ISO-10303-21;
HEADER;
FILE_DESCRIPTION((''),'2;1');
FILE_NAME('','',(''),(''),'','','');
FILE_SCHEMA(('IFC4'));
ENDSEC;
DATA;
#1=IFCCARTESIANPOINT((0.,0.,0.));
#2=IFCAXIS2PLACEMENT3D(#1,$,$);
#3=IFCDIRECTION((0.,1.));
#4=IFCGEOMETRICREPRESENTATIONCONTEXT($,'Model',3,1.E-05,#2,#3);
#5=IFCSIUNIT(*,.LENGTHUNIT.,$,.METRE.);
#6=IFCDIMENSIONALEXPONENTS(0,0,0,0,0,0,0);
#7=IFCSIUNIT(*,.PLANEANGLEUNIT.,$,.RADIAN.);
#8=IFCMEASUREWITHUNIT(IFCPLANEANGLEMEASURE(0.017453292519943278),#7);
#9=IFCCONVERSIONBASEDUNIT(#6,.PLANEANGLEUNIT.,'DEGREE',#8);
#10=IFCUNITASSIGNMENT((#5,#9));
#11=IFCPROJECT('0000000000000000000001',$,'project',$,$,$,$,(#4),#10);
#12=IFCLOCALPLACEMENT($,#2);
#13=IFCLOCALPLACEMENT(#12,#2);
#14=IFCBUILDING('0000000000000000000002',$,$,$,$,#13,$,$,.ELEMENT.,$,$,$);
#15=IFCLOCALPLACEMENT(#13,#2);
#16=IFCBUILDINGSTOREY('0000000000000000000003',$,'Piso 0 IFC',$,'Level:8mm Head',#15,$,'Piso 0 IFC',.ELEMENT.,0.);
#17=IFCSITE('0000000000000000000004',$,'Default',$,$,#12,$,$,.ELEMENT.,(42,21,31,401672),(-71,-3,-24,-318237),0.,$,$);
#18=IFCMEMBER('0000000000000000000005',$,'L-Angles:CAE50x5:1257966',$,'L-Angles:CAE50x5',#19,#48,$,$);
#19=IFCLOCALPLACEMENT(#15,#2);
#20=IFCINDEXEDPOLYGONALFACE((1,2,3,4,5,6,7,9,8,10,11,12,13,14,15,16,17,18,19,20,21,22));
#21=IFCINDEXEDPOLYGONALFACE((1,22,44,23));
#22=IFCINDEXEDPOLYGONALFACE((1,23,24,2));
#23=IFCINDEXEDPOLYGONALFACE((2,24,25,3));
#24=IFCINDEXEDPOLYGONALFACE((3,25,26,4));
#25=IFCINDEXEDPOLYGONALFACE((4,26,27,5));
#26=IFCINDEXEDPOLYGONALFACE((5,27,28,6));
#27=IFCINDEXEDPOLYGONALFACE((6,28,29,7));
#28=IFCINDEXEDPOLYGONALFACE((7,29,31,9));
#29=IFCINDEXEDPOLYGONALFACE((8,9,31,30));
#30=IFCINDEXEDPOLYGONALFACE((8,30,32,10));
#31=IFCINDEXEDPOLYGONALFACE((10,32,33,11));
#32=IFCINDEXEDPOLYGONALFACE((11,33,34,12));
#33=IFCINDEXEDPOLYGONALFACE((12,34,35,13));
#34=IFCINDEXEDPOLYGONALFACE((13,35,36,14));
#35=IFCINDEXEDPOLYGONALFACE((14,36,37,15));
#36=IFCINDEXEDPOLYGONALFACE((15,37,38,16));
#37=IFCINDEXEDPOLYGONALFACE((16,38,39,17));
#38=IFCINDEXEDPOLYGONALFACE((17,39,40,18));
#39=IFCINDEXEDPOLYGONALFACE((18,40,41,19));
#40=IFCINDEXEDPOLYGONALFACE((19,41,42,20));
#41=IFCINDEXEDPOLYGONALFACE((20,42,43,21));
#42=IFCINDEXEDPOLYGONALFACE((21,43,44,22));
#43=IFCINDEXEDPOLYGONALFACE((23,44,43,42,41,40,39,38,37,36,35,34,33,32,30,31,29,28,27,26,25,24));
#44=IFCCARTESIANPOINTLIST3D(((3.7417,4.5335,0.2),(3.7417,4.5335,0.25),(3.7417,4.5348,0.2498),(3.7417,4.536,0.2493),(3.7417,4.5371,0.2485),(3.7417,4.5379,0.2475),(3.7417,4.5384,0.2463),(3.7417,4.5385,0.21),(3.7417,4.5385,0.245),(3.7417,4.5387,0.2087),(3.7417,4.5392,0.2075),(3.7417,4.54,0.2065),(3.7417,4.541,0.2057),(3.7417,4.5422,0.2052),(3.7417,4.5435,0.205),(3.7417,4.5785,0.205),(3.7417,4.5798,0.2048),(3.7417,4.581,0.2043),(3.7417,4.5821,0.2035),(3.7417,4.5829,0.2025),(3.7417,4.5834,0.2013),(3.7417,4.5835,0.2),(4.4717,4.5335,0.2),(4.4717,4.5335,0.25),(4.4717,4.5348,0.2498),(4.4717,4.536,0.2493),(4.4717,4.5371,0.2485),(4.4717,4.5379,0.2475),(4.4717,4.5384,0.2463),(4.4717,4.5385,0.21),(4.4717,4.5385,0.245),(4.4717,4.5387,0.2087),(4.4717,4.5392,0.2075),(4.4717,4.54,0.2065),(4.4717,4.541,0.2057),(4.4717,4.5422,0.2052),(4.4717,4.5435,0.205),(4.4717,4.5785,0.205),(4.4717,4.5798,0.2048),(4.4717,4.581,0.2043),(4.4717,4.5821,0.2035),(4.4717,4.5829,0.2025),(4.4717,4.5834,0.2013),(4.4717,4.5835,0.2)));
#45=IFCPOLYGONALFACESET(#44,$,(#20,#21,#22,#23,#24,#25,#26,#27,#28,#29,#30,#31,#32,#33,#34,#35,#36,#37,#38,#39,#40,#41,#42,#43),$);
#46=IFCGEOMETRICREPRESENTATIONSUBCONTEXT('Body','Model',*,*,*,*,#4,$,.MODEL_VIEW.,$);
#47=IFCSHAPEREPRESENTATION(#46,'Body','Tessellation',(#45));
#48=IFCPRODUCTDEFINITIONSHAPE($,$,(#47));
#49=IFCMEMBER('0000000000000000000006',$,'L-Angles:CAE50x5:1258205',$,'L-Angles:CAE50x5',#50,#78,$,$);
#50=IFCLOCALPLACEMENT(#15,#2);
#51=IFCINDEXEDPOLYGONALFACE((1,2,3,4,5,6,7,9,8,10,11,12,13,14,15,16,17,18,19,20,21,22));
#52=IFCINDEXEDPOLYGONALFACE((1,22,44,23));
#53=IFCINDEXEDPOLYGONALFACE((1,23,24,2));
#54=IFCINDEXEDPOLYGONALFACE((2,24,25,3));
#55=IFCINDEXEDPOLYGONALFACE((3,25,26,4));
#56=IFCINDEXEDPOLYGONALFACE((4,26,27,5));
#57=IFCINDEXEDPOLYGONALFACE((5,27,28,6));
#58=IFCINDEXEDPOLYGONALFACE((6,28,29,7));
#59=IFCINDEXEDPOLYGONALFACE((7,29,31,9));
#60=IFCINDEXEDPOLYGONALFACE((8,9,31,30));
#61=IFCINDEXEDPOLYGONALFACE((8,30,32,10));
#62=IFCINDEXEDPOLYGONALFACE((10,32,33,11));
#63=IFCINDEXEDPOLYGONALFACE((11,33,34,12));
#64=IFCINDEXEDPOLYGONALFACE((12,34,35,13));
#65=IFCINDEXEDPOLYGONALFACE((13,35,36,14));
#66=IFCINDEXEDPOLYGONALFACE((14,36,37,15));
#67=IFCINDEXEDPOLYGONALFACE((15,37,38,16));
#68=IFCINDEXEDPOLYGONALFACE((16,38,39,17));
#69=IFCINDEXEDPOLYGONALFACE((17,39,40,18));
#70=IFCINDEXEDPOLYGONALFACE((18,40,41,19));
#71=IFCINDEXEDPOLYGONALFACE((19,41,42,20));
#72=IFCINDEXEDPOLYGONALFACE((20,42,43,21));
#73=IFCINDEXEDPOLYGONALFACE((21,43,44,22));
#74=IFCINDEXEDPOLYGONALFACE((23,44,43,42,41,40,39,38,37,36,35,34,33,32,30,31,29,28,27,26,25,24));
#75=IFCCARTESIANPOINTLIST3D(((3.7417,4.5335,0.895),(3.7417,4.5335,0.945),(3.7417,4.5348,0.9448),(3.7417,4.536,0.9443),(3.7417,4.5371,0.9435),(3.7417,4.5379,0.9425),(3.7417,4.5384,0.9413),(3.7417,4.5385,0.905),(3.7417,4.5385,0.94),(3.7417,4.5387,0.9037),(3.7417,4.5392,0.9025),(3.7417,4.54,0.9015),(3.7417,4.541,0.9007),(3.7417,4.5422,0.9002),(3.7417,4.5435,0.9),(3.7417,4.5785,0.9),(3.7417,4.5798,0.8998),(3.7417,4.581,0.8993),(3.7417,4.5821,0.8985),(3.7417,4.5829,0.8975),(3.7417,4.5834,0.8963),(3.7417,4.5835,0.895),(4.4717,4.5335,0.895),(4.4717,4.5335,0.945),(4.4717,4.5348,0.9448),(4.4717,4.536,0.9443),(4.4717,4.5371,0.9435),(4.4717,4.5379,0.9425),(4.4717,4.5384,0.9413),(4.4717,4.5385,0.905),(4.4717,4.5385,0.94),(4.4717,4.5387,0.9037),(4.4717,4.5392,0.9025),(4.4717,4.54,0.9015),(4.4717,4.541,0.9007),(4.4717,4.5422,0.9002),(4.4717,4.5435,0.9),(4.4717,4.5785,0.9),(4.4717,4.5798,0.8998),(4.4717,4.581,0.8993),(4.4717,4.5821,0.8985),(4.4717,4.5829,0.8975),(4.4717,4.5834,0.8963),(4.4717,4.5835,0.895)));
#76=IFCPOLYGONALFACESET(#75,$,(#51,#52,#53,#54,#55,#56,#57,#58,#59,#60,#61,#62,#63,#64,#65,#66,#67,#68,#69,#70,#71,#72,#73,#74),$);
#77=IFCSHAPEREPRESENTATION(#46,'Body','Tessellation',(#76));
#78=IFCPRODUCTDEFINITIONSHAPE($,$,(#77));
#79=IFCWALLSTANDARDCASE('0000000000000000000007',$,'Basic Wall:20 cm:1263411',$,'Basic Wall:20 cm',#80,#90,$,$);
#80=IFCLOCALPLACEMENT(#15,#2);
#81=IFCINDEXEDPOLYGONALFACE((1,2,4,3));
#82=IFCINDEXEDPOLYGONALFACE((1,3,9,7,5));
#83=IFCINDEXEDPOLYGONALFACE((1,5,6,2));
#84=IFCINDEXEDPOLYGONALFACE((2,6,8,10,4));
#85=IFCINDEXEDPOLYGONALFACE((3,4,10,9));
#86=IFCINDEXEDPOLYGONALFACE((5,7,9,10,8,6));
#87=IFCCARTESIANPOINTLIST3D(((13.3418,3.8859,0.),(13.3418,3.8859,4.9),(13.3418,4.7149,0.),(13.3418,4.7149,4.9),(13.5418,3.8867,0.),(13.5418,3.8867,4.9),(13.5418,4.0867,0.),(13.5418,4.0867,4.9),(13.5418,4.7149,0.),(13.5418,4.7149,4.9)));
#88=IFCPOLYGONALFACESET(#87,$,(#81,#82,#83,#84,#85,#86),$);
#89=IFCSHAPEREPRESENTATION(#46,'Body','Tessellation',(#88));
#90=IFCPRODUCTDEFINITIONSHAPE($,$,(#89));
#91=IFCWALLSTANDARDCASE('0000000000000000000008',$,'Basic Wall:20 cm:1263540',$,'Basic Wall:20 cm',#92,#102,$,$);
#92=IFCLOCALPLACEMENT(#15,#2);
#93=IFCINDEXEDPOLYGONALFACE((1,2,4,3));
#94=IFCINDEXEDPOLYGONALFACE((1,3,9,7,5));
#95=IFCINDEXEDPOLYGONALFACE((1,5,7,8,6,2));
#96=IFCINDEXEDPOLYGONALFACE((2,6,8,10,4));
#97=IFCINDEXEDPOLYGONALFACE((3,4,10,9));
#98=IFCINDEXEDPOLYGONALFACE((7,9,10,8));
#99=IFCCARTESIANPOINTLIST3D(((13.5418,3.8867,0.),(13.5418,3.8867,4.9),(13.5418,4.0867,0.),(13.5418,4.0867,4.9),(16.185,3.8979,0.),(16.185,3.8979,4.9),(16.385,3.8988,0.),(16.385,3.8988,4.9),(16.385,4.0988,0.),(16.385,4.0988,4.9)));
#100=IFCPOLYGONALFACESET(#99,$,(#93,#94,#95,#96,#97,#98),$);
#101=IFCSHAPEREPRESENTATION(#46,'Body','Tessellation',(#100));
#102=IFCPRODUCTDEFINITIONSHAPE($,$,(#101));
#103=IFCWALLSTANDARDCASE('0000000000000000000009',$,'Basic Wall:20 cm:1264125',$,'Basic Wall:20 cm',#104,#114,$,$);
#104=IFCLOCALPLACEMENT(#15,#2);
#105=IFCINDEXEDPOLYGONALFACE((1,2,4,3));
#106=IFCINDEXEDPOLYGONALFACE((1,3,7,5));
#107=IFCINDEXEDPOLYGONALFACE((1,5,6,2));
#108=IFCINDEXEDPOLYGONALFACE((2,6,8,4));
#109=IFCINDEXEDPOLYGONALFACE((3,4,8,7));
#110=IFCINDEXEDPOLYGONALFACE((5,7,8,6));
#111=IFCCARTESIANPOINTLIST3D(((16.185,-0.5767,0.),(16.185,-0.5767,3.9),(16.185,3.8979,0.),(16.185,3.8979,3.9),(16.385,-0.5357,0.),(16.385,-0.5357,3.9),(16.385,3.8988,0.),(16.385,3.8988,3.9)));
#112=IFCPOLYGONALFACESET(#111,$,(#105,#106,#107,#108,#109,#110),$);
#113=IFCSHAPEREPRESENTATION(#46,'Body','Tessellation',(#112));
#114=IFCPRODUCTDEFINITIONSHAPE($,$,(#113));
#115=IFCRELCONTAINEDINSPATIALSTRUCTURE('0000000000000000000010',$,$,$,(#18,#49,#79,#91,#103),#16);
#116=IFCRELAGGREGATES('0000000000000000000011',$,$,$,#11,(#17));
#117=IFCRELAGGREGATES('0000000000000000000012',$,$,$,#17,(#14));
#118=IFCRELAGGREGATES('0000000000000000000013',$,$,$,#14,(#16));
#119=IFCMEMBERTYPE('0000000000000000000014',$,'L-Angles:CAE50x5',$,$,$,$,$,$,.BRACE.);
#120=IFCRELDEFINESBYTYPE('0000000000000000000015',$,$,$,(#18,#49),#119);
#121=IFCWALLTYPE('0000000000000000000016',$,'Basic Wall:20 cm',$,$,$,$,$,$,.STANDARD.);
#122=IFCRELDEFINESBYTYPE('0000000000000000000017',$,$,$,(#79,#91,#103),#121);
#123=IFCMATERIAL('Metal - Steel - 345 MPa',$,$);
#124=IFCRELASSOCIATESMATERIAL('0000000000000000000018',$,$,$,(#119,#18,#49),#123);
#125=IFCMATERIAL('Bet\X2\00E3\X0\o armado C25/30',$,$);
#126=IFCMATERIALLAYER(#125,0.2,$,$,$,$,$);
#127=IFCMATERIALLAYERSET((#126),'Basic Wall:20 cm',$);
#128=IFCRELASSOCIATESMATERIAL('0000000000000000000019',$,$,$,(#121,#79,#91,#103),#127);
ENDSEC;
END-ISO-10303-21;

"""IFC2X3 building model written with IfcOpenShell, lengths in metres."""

from ifc_helpers import new_model, entity, si_unit, converted_unit, direction, frame, frame_2d, origin, place, context, subcontext, project, spatial, polyline, circle_curve, parameter, trimmed, segment, composite_curve, outline, extrude, source, transform, mapped, material, layer, layer_set, layer_usage, type_object, type_shapes, element, save


model = new_model("IFC2X3")

# Units and contexts
model_context = context("Model", 3, precision=1e-05, world=origin(), true_north=direction((0.0, 1.0)))
body_context = subcontext(model_context, "Body", "Model", "MODEL_VIEW")
ifc_project = project(units=[si_unit("LENGTHUNIT", "METRE"), converted_unit("PLANEANGLEUNIT", "DEGREE", entity("IfcPlaneAngleMeasure", 0.017453292519943278), si_unit("PLANEANGLEUNIT", "RADIAN"), dimensions=[0, 0, 0, 0, 0, 0, 0])], contexts=[model_context])

# Site, building, storey
site_placement = place(None, origin())
site = spatial("IfcSite", under=ifc_project, at=site_placement, Name="Default", CompositionType="ELEMENT", RefLatitude=(42, 21, 31, 401672), RefLongitude=(-71, -3, -24, -318237), RefElevation=0.0)
building_placement = place(site_placement, origin())
building = spatial("IfcBuilding", under=site, at=building_placement, CompositionType="ELEMENT")
storey_placement = place(building_placement, origin())
storey = spatial("IfcBuildingStorey", under=building, at=storey_placement, Name="Piso 0 IFC", ObjectType="Level:8mm Head", LongName="Piso 0 IFC", CompositionType="ELEMENT", Elevation=0.0)

# Shared definitions
ifc_material_1 = material(Name="Metal - Steel - 345 MPa")

# Members
member_type_1 = type_object("IfcMemberType", Name="L-Angles:CAE50x5", PredefinedType="BRACE", material=ifc_material_1)
shared_shape_1 = source(origin(), body_context, "Body", "SweptSolid", [
    extrude(outline(composite_curve([segment(polyline([(-0.0164, -0.0164), (0.0336, -0.0164)]), True, "CONTINUOUS"), segment(trimmed(circle_curve(frame_2d((0.0286, -0.0164), x_axis=(1.0, 0.0)), 0.005), [parameter(0.0)], [parameter(90.0)], True, "PARAMETER"), True, "CONTINUOUS"), segment(polyline([(0.0286, -0.0114), (-0.0064, -0.0114)]), True, "CONTINUOUS"), segment(trimmed(circle_curve(frame_2d((-0.0064, -0.0064), x_axis=(1.0, 0.0)), 0.005), [parameter(180.0)], [parameter(270.0)], True, "PARAMETER"), False, "CONTINUOUS"), segment(polyline([(-0.0114, -0.0064), (-0.0114, 0.0286)]), True, "CONTINUOUS"), segment(trimmed(circle_curve(frame_2d((-0.0164, 0.0286), x_axis=(1.0, 0.0)), 0.005), [parameter(0.0)], [parameter(90.0)], True, "PARAMETER"), True, "CONTINUOUS"), segment(polyline([(-0.0164, 0.0336), (-0.0164, -0.0164)]), True, "CONTINUOUS")], self_intersect=False)), frame((-0.365, -0.0024, -0.0024), z_axis=(1.0, 0.0, 0.0), x_axis=(0.0, -1.0, 0.0)), (0.0, 0.0, 1.0), 0.73),
])
type_shapes(member_type_1, [shared_shape_1])
for number, where, z_axis, x_axis, name in (
    (1, (4.1067, 4.5475, 0.214), (0.0, -1.0, 0.0), (-1.0, 0.0, 0.0), "L-Angles:CAE50x5:1257966"),
    (2, (4.1067, 4.5475, 0.909), (0.0, -1.0, 0.0), (-1.0, 0.0, 0.0), "L-Angles:CAE50x5:1258205"),
):
    element("IfcMember", number, at=place(storey_placement, frame(where, z_axis=z_axis, x_axis=x_axis)), inside=storey, type_object=member_type_1, material=ifc_material_1, Name=name, ObjectType="L-Angles:CAE50x5", context=body_context, shape_type="MappedRepresentation", body=[
        mapped(shared_shape_1, transform((0.0, 0.0, 0.0), scale=1.0)),
    ])

# Walls
ifc_material_2 = material(Name="Betão armado C25/30")
ifc_layer = layer(ifc_material_2, 0.2)
ifc_layer_set = layer_set([ifc_layer], Name="Basic Wall:20 cm")
ifc_layer_usage_1 = layer_usage(ifc_layer_set, "AXIS2", "NEGATIVE", 0.1)
wall_type = type_object("IfcWallType", Name="Basic Wall:20 cm", PredefinedType="STANDARD", material=ifc_layer_set)
wall_1_placement = place(storey_placement, frame((13.4418, 4.7149, 0.0), z_axis=(0.0, 0.0, 1.0), x_axis=(0.0, -1.0, 0.0)))
element("IfcWallStandardCase", 3, at=wall_1_placement, inside=storey, type_object=wall_type, material=ifc_layer_usage_1, Name="Basic Wall:20 cm:1263411", ObjectType="Basic Wall:20 cm", context=body_context, shape_type="SweptSolid", body=[
    extrude(outline(polyline([(0.829, -0.1), (0.8281, 0.1), (0.6281, 0.1), (0.0, 0.1), (0.0, -0.1), (0.829, -0.1)])), origin(), (0.0, 0.0, 1.0), 4.9),
])
ifc_layer_usage_2 = layer_usage(ifc_layer_set, "AXIS2", "NEGATIVE", 0.1)
wall_2_placement = place(storey_placement, frame((13.5414, 3.9867, 0.0), z_axis=(0.0, 0.0, 1.0), x_axis=(0.999991, 0.00423, 0.0)))
element("IfcWallStandardCase", 4, at=wall_2_placement, inside=storey, type_object=wall_type, material=ifc_layer_usage_2, Name="Basic Wall:20 cm:1263540", ObjectType="Basic Wall:20 cm", context=body_context, shape_type="SweptSolid", body=[
    extrude(outline(polyline([(2.8432, -0.1), (2.8441, 0.1), (0.0008, 0.1), (0.0, -0.1), (2.6432, -0.1), (2.8432, -0.1)])), origin(), (0.0, 0.0, 1.0), 4.9),
])
ifc_layer_usage_3 = layer_usage(ifc_layer_set, "AXIS2", "NEGATIVE", 0.1)
wall_3_placement = place(storey_placement, frame((16.285, 3.8988, 0.0), z_axis=(0.0, 0.0, 1.0), x_axis=(0.0, -1.0, 0.0)))
element("IfcWallStandardCase", 5, at=wall_3_placement, inside=storey, type_object=wall_type, material=ifc_layer_usage_3, Name="Basic Wall:20 cm:1264125", ObjectType="Basic Wall:20 cm", context=body_context, shape_type="SweptSolid", body=[
    extrude(outline(polyline([(4.4754, -0.1), (4.4345, 0.1), (0.0, 0.1), (0.0008, -0.1), (4.4754, -0.1)])), origin(), (0.0, 0.0, 1.0), 3.9),
])

save(model, "model.ifc")
